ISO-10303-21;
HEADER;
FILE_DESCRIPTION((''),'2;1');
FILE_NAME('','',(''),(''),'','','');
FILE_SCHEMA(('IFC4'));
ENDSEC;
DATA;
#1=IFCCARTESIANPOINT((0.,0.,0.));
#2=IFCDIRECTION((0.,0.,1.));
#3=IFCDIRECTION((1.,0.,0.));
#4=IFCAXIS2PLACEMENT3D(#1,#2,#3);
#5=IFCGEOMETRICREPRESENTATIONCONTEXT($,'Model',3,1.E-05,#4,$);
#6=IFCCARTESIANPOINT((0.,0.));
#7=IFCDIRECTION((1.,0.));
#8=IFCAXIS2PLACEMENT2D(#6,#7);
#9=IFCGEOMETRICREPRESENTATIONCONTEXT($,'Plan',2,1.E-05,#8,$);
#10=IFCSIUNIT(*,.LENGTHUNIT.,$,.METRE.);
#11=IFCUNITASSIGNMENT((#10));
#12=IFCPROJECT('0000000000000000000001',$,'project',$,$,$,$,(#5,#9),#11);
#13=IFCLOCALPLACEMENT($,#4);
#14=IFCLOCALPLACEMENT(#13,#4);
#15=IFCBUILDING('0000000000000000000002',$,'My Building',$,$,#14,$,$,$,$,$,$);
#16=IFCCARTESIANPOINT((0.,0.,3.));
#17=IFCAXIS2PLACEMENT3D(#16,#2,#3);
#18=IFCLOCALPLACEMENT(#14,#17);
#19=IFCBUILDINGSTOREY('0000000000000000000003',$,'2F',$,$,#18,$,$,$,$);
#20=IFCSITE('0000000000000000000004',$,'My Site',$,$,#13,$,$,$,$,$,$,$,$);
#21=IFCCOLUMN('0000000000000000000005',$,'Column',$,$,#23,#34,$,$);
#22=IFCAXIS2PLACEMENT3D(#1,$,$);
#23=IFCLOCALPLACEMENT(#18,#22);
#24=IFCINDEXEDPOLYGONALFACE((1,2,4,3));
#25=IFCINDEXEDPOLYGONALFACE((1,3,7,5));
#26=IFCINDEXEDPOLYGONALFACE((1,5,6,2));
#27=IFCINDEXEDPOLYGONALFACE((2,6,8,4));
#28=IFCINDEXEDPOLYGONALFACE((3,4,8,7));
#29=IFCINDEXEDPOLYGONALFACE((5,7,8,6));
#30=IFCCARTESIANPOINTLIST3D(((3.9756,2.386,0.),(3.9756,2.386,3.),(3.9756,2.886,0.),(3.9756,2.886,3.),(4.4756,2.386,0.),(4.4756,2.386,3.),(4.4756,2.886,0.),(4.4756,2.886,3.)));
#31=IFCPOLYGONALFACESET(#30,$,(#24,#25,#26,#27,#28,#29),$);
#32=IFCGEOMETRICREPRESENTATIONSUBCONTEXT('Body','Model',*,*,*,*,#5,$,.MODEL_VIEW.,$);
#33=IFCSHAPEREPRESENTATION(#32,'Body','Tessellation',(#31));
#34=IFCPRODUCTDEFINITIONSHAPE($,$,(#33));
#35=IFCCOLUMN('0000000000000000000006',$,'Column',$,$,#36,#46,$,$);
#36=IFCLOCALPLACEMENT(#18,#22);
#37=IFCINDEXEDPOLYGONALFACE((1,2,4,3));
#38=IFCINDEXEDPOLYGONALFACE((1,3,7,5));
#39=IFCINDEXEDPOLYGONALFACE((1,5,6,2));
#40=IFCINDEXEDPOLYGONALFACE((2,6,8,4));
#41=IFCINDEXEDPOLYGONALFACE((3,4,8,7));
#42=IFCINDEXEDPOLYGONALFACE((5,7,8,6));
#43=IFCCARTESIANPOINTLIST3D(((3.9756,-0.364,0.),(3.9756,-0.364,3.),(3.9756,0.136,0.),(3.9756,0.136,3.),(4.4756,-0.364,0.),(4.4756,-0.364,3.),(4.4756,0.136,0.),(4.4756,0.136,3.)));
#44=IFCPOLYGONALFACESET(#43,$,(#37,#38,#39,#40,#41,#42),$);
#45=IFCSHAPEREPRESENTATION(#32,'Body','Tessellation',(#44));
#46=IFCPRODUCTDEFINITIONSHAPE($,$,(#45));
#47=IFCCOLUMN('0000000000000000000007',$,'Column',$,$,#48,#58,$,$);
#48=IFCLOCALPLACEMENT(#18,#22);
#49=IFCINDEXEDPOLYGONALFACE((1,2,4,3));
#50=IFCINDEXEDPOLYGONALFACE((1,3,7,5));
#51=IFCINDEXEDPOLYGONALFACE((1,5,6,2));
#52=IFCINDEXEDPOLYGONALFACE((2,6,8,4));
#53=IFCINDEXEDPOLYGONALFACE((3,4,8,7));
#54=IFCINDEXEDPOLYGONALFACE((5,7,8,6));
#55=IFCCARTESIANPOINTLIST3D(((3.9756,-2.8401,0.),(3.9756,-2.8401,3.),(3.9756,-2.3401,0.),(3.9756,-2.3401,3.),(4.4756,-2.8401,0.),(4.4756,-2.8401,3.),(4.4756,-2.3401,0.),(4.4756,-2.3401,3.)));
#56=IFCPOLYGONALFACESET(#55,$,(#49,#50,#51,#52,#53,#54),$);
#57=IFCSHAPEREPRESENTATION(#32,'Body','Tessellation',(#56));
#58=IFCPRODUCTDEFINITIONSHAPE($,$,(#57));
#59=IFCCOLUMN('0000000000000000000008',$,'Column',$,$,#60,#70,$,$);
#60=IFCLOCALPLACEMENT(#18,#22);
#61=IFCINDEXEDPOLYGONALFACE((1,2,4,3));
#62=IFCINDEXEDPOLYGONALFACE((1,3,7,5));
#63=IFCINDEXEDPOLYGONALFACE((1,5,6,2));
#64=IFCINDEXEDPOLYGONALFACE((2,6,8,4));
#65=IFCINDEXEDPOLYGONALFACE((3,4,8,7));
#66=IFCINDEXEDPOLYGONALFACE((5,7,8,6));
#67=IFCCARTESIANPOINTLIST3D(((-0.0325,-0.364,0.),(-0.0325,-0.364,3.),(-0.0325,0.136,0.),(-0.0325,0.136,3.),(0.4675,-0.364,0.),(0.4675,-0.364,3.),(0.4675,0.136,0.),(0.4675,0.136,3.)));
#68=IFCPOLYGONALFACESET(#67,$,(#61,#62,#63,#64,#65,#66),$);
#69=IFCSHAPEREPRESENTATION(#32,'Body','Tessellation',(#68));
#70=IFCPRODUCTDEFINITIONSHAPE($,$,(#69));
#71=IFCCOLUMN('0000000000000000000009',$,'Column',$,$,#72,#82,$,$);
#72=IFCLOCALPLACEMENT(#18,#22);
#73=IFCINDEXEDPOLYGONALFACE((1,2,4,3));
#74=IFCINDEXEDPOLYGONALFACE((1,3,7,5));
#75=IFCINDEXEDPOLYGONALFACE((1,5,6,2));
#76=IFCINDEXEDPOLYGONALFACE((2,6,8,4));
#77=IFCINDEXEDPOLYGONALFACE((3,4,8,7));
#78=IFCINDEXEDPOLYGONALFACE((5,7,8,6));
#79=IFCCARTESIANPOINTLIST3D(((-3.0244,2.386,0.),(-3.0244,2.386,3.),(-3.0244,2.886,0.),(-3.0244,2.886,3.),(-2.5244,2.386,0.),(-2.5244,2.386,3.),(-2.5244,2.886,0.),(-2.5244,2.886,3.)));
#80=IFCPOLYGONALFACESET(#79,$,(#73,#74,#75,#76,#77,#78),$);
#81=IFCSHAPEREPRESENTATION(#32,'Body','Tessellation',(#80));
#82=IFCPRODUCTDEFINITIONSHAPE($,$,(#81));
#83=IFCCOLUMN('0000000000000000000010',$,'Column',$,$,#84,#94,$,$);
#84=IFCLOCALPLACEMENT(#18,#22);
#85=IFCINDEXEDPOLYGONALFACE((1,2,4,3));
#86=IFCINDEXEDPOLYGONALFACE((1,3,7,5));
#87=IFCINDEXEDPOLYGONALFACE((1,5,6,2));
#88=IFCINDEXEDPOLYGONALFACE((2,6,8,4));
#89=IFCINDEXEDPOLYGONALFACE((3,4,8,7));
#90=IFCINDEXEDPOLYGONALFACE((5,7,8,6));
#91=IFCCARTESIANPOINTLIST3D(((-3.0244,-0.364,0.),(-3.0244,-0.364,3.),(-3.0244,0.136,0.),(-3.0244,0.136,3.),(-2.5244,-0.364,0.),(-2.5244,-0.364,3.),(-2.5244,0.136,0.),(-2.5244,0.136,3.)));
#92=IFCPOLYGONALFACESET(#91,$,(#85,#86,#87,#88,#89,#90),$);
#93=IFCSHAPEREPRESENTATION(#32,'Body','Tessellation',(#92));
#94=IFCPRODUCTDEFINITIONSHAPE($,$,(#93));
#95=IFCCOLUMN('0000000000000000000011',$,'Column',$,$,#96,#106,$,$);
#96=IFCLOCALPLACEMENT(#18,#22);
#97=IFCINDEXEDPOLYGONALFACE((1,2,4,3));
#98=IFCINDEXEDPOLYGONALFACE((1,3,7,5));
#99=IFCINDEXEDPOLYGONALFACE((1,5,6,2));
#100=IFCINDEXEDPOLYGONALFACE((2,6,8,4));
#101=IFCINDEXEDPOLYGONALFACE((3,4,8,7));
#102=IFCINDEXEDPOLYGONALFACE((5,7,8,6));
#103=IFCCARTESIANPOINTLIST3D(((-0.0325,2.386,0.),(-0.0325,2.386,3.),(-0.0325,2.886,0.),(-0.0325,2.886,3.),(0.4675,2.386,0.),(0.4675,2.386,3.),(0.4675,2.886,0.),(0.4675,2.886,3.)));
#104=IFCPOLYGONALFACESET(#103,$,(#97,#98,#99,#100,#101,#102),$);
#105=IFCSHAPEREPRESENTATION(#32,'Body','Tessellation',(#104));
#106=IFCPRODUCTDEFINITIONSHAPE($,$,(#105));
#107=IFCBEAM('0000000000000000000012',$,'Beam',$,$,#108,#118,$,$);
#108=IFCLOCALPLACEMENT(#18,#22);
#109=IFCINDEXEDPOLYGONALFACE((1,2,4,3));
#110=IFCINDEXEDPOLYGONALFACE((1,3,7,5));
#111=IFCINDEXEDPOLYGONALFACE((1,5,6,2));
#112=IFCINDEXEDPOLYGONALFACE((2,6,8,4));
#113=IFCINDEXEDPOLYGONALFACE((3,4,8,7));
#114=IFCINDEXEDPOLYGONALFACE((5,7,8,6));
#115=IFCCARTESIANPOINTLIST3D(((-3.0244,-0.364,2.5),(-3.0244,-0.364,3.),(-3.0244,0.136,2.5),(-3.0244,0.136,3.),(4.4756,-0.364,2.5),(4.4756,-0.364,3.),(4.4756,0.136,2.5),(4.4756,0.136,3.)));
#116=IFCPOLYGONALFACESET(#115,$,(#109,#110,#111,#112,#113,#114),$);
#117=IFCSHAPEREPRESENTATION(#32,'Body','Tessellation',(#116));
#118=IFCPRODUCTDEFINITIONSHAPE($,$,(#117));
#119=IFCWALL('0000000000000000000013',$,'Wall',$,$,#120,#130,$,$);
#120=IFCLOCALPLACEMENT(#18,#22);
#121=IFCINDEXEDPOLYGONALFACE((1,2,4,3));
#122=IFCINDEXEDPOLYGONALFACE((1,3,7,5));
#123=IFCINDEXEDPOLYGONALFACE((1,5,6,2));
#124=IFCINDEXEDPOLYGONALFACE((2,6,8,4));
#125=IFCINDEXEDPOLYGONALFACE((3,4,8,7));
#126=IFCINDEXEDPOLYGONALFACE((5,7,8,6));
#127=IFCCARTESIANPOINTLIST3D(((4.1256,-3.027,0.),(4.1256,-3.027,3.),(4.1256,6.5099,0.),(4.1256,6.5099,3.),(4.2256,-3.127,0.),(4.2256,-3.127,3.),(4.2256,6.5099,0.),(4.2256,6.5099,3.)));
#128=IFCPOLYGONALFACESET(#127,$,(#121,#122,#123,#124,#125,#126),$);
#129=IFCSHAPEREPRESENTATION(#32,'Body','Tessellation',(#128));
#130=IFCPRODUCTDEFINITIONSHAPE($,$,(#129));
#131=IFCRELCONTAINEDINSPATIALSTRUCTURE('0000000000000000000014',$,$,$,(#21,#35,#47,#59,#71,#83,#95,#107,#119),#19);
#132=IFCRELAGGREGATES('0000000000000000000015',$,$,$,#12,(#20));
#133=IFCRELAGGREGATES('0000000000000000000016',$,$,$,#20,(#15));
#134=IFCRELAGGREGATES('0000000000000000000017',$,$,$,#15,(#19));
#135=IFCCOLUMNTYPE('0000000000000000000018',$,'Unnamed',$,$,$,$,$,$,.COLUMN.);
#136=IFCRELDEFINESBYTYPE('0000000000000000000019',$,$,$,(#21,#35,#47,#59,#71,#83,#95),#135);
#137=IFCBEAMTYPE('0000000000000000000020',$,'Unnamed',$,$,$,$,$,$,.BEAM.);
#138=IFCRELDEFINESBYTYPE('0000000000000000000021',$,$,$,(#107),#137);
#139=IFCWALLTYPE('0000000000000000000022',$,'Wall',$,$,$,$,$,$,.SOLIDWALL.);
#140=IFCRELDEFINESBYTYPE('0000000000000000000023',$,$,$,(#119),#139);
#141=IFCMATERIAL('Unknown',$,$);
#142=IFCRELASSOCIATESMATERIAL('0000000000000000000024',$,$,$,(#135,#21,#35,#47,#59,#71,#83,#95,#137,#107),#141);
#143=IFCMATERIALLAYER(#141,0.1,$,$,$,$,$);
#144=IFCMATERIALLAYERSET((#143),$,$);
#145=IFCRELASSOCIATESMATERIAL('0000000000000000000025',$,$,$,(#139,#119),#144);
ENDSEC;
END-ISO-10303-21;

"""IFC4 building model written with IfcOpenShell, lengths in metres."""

from ifc_helpers import new_model, si_unit, frame, origin_with_axes, origin_2d_with_axis, place, context, subcontext, project, spatial, line, indexed_curve, rectangle, outline, extrude, material, layer, layer_set, layer_usage, material_profile, profile_set, profile_usage, type_object, element, save


model = new_model("IFC4")

# Units and contexts
model_context = context("Model", 3, precision=1e-05, world=origin_with_axes())
plan_context = context("Plan", 2, precision=1e-05, world=origin_2d_with_axis())
body_context_1 = subcontext(model_context, "Body", "Model", "MODEL_VIEW")
ifc_project = project(units=[si_unit("LENGTHUNIT", "METRE")], contexts=[model_context, plan_context])

# Site, building, storey
site_placement = place(None, origin_with_axes())
site = spatial("IfcSite", under=ifc_project, at=site_placement, Name="My Site")
building_placement = place(site_placement, origin_with_axes())
building = spatial("IfcBuilding", under=site, at=building_placement, Name="My Building")
storey_placement = place(building_placement, frame((0.0, 0.0, 3.0), z_axis=(0.0, 0.0, 1.0), x_axis=(1.0, 0.0, 0.0)))
storey = spatial("IfcBuildingStorey", under=building, at=storey_placement, Name="2F")

# Columns
ifc_material = material(Name="Unknown")
ifc_material_profile_1 = material_profile(ifc_material, rectangle(XDim=0.5, YDim=0.5))
ifc_profile_set_1 = profile_set([ifc_material_profile_1])
ifc_profile_usage_1 = profile_usage(ifc_profile_set_1, cardinal=5)
column_type = type_object("IfcColumnType", Name="Unnamed", PredefinedType="COLUMN", material=ifc_profile_set_1)
column_1_placement = place(storey_placement, frame((4.2256, 2.636, 0.0), z_axis=(0.0, 0.0, 1.0), x_axis=(1.0, 0.0, 0.0)))
element("IfcColumn", 1, at=column_1_placement, inside=storey, type_object=column_type, material=ifc_profile_usage_1, Name="Column", context=body_context_1, shape_type="SweptSolid", body=[
    extrude(rectangle(XDim=0.5, YDim=0.5), origin_with_axes(), (0.0, 0.0, 1.0), 3.0),
])
ifc_profile_usage_2 = profile_usage(ifc_profile_set_1, cardinal=5)
column_2_placement = place(storey_placement, frame((4.2256, -0.114, 0.0), z_axis=(0.0, 0.0, 1.0), x_axis=(1.0, 0.0, 0.0)))
element("IfcColumn", 2, at=column_2_placement, inside=storey, type_object=column_type, material=ifc_profile_usage_2, Name="Column", context=body_context_1, shape_type="SweptSolid", body=[
    extrude(rectangle(XDim=0.5, YDim=0.5), origin_with_axes(), (0.0, 0.0, 1.0), 3.0),
])
ifc_profile_usage_3 = profile_usage(ifc_profile_set_1, cardinal=5)
column_3_placement = place(storey_placement, frame((4.2256, -2.5901, 0.0), z_axis=(0.0, 0.0, 1.0), x_axis=(1.0, 0.0, 0.0)))
element("IfcColumn", 3, at=column_3_placement, inside=storey, type_object=column_type, material=ifc_profile_usage_3, Name="Column", context=body_context_1, shape_type="SweptSolid", body=[
    extrude(rectangle(XDim=0.5, YDim=0.5), origin_with_axes(), (0.0, 0.0, 1.0), 3.0),
])
ifc_profile_usage_4 = profile_usage(ifc_profile_set_1, cardinal=5)
column_4_placement = place(storey_placement, frame((0.2175, -0.114, 0.0), z_axis=(0.0, 0.0, 1.0), x_axis=(1.0, 0.0, 0.0)))
element("IfcColumn", 4, at=column_4_placement, inside=storey, type_object=column_type, material=ifc_profile_usage_4, Name="Column", context=body_context_1, shape_type="SweptSolid", body=[
    extrude(rectangle(XDim=0.5, YDim=0.5), origin_with_axes(), (0.0, 0.0, 1.0), 3.0),
])
ifc_profile_usage_5 = profile_usage(ifc_profile_set_1, cardinal=5)
column_5_placement = place(storey_placement, frame((-2.7744, 2.636, 0.0), z_axis=(0.0, 0.0, 1.0), x_axis=(1.0, 0.0, 0.0)))
element("IfcColumn", 5, at=column_5_placement, inside=storey, type_object=column_type, material=ifc_profile_usage_5, Name="Column", context=body_context_1, shape_type="SweptSolid", body=[
    extrude(rectangle(XDim=0.5, YDim=0.5), origin_with_axes(), (0.0, 0.0, 1.0), 3.0),
])
ifc_profile_usage_6 = profile_usage(ifc_profile_set_1, cardinal=5)
column_6_placement = place(storey_placement, frame((-2.7744, -0.114, 0.0), z_axis=(0.0, 0.0, 1.0), x_axis=(1.0, 0.0, 0.0)))
element("IfcColumn", 6, at=column_6_placement, inside=storey, type_object=column_type, material=ifc_profile_usage_6, Name="Column", context=body_context_1, shape_type="SweptSolid", body=[
    extrude(rectangle(XDim=0.5, YDim=0.5), origin_with_axes(), (0.0, 0.0, 1.0), 3.0),
])
ifc_profile_usage_7 = profile_usage(ifc_profile_set_1, cardinal=5)
column_7_placement = place(storey_placement, frame((0.2175, 2.636, 0.0), z_axis=(0.0, 0.0, 1.0), x_axis=(1.0, 0.0, 0.0)))
element("IfcColumn", 7, at=column_7_placement, inside=storey, type_object=column_type, material=ifc_profile_usage_7, Name="Column", context=body_context_1, shape_type="SweptSolid", body=[
    extrude(rectangle(XDim=0.5, YDim=0.5), origin_with_axes(), (0.0, 0.0, 1.0), 3.0),
])

# Beam
ifc_material_profile_2 = material_profile(ifc_material, rectangle(XDim=0.5, YDim=0.5))
ifc_profile_set_2 = profile_set([ifc_material_profile_2])
ifc_profile_usage_8 = profile_usage(ifc_profile_set_2, cardinal=7)
beam_type = type_object("IfcBeamType", Name="Unnamed", PredefinedType="BEAM", material=ifc_profile_set_2)
beam_placement = place(storey_placement, frame((-3.0244, 0.136, 3.0), z_axis=(1.0, 0.0, 0.0), x_axis=(0.0, 1.0, 0.0)))
element("IfcBeam", 8, at=beam_placement, inside=storey, type_object=beam_type, material=ifc_profile_usage_8, Name="Beam", context=body_context_1, shape_type="SweptSolid", body=[
    extrude(rectangle(XDim=0.5, YDim=0.5), frame((-0.25, -0.25, 0.0), z_axis=(0.0, 0.0, 1.0), x_axis=(1.0, 0.0, 0.0)), (0.0, 0.0, 1.0), 7.5),
])

# Wall
ifc_layer = layer(ifc_material, 0.1)
ifc_layer_set = layer_set([ifc_layer])
ifc_layer_usage_1 = layer_usage(ifc_layer_set, "AXIS2", "POSITIVE", 0.0)
wall_type = type_object("IfcWallType", Name="Wall", PredefinedType="SOLIDWALL", material=ifc_layer_set)
wall_1_placement = place(storey_placement, frame((4.2256, -3.127, 0.0), z_axis=(0.0, 0.0, 1.0), x_axis=(0.0, 1.0, 0.0)))
element("IfcWall", 9, at=wall_1_placement, inside=storey, type_object=wall_type, material=ifc_layer_usage_1, Name="Wall", context=body_context_1, shape_type="SweptSolid", body=[
    extrude(outline(indexed_curve([(0.0, 0.0), (0.1, 0.1), (9.6369, 0.1), (9.6369, 0.0)], segments=[line(1, 2, 3, 4, 1)])), origin_with_axes(), (0.0, 0.0, 1.0), 3.0),
])

save(model, "model.ifc")
